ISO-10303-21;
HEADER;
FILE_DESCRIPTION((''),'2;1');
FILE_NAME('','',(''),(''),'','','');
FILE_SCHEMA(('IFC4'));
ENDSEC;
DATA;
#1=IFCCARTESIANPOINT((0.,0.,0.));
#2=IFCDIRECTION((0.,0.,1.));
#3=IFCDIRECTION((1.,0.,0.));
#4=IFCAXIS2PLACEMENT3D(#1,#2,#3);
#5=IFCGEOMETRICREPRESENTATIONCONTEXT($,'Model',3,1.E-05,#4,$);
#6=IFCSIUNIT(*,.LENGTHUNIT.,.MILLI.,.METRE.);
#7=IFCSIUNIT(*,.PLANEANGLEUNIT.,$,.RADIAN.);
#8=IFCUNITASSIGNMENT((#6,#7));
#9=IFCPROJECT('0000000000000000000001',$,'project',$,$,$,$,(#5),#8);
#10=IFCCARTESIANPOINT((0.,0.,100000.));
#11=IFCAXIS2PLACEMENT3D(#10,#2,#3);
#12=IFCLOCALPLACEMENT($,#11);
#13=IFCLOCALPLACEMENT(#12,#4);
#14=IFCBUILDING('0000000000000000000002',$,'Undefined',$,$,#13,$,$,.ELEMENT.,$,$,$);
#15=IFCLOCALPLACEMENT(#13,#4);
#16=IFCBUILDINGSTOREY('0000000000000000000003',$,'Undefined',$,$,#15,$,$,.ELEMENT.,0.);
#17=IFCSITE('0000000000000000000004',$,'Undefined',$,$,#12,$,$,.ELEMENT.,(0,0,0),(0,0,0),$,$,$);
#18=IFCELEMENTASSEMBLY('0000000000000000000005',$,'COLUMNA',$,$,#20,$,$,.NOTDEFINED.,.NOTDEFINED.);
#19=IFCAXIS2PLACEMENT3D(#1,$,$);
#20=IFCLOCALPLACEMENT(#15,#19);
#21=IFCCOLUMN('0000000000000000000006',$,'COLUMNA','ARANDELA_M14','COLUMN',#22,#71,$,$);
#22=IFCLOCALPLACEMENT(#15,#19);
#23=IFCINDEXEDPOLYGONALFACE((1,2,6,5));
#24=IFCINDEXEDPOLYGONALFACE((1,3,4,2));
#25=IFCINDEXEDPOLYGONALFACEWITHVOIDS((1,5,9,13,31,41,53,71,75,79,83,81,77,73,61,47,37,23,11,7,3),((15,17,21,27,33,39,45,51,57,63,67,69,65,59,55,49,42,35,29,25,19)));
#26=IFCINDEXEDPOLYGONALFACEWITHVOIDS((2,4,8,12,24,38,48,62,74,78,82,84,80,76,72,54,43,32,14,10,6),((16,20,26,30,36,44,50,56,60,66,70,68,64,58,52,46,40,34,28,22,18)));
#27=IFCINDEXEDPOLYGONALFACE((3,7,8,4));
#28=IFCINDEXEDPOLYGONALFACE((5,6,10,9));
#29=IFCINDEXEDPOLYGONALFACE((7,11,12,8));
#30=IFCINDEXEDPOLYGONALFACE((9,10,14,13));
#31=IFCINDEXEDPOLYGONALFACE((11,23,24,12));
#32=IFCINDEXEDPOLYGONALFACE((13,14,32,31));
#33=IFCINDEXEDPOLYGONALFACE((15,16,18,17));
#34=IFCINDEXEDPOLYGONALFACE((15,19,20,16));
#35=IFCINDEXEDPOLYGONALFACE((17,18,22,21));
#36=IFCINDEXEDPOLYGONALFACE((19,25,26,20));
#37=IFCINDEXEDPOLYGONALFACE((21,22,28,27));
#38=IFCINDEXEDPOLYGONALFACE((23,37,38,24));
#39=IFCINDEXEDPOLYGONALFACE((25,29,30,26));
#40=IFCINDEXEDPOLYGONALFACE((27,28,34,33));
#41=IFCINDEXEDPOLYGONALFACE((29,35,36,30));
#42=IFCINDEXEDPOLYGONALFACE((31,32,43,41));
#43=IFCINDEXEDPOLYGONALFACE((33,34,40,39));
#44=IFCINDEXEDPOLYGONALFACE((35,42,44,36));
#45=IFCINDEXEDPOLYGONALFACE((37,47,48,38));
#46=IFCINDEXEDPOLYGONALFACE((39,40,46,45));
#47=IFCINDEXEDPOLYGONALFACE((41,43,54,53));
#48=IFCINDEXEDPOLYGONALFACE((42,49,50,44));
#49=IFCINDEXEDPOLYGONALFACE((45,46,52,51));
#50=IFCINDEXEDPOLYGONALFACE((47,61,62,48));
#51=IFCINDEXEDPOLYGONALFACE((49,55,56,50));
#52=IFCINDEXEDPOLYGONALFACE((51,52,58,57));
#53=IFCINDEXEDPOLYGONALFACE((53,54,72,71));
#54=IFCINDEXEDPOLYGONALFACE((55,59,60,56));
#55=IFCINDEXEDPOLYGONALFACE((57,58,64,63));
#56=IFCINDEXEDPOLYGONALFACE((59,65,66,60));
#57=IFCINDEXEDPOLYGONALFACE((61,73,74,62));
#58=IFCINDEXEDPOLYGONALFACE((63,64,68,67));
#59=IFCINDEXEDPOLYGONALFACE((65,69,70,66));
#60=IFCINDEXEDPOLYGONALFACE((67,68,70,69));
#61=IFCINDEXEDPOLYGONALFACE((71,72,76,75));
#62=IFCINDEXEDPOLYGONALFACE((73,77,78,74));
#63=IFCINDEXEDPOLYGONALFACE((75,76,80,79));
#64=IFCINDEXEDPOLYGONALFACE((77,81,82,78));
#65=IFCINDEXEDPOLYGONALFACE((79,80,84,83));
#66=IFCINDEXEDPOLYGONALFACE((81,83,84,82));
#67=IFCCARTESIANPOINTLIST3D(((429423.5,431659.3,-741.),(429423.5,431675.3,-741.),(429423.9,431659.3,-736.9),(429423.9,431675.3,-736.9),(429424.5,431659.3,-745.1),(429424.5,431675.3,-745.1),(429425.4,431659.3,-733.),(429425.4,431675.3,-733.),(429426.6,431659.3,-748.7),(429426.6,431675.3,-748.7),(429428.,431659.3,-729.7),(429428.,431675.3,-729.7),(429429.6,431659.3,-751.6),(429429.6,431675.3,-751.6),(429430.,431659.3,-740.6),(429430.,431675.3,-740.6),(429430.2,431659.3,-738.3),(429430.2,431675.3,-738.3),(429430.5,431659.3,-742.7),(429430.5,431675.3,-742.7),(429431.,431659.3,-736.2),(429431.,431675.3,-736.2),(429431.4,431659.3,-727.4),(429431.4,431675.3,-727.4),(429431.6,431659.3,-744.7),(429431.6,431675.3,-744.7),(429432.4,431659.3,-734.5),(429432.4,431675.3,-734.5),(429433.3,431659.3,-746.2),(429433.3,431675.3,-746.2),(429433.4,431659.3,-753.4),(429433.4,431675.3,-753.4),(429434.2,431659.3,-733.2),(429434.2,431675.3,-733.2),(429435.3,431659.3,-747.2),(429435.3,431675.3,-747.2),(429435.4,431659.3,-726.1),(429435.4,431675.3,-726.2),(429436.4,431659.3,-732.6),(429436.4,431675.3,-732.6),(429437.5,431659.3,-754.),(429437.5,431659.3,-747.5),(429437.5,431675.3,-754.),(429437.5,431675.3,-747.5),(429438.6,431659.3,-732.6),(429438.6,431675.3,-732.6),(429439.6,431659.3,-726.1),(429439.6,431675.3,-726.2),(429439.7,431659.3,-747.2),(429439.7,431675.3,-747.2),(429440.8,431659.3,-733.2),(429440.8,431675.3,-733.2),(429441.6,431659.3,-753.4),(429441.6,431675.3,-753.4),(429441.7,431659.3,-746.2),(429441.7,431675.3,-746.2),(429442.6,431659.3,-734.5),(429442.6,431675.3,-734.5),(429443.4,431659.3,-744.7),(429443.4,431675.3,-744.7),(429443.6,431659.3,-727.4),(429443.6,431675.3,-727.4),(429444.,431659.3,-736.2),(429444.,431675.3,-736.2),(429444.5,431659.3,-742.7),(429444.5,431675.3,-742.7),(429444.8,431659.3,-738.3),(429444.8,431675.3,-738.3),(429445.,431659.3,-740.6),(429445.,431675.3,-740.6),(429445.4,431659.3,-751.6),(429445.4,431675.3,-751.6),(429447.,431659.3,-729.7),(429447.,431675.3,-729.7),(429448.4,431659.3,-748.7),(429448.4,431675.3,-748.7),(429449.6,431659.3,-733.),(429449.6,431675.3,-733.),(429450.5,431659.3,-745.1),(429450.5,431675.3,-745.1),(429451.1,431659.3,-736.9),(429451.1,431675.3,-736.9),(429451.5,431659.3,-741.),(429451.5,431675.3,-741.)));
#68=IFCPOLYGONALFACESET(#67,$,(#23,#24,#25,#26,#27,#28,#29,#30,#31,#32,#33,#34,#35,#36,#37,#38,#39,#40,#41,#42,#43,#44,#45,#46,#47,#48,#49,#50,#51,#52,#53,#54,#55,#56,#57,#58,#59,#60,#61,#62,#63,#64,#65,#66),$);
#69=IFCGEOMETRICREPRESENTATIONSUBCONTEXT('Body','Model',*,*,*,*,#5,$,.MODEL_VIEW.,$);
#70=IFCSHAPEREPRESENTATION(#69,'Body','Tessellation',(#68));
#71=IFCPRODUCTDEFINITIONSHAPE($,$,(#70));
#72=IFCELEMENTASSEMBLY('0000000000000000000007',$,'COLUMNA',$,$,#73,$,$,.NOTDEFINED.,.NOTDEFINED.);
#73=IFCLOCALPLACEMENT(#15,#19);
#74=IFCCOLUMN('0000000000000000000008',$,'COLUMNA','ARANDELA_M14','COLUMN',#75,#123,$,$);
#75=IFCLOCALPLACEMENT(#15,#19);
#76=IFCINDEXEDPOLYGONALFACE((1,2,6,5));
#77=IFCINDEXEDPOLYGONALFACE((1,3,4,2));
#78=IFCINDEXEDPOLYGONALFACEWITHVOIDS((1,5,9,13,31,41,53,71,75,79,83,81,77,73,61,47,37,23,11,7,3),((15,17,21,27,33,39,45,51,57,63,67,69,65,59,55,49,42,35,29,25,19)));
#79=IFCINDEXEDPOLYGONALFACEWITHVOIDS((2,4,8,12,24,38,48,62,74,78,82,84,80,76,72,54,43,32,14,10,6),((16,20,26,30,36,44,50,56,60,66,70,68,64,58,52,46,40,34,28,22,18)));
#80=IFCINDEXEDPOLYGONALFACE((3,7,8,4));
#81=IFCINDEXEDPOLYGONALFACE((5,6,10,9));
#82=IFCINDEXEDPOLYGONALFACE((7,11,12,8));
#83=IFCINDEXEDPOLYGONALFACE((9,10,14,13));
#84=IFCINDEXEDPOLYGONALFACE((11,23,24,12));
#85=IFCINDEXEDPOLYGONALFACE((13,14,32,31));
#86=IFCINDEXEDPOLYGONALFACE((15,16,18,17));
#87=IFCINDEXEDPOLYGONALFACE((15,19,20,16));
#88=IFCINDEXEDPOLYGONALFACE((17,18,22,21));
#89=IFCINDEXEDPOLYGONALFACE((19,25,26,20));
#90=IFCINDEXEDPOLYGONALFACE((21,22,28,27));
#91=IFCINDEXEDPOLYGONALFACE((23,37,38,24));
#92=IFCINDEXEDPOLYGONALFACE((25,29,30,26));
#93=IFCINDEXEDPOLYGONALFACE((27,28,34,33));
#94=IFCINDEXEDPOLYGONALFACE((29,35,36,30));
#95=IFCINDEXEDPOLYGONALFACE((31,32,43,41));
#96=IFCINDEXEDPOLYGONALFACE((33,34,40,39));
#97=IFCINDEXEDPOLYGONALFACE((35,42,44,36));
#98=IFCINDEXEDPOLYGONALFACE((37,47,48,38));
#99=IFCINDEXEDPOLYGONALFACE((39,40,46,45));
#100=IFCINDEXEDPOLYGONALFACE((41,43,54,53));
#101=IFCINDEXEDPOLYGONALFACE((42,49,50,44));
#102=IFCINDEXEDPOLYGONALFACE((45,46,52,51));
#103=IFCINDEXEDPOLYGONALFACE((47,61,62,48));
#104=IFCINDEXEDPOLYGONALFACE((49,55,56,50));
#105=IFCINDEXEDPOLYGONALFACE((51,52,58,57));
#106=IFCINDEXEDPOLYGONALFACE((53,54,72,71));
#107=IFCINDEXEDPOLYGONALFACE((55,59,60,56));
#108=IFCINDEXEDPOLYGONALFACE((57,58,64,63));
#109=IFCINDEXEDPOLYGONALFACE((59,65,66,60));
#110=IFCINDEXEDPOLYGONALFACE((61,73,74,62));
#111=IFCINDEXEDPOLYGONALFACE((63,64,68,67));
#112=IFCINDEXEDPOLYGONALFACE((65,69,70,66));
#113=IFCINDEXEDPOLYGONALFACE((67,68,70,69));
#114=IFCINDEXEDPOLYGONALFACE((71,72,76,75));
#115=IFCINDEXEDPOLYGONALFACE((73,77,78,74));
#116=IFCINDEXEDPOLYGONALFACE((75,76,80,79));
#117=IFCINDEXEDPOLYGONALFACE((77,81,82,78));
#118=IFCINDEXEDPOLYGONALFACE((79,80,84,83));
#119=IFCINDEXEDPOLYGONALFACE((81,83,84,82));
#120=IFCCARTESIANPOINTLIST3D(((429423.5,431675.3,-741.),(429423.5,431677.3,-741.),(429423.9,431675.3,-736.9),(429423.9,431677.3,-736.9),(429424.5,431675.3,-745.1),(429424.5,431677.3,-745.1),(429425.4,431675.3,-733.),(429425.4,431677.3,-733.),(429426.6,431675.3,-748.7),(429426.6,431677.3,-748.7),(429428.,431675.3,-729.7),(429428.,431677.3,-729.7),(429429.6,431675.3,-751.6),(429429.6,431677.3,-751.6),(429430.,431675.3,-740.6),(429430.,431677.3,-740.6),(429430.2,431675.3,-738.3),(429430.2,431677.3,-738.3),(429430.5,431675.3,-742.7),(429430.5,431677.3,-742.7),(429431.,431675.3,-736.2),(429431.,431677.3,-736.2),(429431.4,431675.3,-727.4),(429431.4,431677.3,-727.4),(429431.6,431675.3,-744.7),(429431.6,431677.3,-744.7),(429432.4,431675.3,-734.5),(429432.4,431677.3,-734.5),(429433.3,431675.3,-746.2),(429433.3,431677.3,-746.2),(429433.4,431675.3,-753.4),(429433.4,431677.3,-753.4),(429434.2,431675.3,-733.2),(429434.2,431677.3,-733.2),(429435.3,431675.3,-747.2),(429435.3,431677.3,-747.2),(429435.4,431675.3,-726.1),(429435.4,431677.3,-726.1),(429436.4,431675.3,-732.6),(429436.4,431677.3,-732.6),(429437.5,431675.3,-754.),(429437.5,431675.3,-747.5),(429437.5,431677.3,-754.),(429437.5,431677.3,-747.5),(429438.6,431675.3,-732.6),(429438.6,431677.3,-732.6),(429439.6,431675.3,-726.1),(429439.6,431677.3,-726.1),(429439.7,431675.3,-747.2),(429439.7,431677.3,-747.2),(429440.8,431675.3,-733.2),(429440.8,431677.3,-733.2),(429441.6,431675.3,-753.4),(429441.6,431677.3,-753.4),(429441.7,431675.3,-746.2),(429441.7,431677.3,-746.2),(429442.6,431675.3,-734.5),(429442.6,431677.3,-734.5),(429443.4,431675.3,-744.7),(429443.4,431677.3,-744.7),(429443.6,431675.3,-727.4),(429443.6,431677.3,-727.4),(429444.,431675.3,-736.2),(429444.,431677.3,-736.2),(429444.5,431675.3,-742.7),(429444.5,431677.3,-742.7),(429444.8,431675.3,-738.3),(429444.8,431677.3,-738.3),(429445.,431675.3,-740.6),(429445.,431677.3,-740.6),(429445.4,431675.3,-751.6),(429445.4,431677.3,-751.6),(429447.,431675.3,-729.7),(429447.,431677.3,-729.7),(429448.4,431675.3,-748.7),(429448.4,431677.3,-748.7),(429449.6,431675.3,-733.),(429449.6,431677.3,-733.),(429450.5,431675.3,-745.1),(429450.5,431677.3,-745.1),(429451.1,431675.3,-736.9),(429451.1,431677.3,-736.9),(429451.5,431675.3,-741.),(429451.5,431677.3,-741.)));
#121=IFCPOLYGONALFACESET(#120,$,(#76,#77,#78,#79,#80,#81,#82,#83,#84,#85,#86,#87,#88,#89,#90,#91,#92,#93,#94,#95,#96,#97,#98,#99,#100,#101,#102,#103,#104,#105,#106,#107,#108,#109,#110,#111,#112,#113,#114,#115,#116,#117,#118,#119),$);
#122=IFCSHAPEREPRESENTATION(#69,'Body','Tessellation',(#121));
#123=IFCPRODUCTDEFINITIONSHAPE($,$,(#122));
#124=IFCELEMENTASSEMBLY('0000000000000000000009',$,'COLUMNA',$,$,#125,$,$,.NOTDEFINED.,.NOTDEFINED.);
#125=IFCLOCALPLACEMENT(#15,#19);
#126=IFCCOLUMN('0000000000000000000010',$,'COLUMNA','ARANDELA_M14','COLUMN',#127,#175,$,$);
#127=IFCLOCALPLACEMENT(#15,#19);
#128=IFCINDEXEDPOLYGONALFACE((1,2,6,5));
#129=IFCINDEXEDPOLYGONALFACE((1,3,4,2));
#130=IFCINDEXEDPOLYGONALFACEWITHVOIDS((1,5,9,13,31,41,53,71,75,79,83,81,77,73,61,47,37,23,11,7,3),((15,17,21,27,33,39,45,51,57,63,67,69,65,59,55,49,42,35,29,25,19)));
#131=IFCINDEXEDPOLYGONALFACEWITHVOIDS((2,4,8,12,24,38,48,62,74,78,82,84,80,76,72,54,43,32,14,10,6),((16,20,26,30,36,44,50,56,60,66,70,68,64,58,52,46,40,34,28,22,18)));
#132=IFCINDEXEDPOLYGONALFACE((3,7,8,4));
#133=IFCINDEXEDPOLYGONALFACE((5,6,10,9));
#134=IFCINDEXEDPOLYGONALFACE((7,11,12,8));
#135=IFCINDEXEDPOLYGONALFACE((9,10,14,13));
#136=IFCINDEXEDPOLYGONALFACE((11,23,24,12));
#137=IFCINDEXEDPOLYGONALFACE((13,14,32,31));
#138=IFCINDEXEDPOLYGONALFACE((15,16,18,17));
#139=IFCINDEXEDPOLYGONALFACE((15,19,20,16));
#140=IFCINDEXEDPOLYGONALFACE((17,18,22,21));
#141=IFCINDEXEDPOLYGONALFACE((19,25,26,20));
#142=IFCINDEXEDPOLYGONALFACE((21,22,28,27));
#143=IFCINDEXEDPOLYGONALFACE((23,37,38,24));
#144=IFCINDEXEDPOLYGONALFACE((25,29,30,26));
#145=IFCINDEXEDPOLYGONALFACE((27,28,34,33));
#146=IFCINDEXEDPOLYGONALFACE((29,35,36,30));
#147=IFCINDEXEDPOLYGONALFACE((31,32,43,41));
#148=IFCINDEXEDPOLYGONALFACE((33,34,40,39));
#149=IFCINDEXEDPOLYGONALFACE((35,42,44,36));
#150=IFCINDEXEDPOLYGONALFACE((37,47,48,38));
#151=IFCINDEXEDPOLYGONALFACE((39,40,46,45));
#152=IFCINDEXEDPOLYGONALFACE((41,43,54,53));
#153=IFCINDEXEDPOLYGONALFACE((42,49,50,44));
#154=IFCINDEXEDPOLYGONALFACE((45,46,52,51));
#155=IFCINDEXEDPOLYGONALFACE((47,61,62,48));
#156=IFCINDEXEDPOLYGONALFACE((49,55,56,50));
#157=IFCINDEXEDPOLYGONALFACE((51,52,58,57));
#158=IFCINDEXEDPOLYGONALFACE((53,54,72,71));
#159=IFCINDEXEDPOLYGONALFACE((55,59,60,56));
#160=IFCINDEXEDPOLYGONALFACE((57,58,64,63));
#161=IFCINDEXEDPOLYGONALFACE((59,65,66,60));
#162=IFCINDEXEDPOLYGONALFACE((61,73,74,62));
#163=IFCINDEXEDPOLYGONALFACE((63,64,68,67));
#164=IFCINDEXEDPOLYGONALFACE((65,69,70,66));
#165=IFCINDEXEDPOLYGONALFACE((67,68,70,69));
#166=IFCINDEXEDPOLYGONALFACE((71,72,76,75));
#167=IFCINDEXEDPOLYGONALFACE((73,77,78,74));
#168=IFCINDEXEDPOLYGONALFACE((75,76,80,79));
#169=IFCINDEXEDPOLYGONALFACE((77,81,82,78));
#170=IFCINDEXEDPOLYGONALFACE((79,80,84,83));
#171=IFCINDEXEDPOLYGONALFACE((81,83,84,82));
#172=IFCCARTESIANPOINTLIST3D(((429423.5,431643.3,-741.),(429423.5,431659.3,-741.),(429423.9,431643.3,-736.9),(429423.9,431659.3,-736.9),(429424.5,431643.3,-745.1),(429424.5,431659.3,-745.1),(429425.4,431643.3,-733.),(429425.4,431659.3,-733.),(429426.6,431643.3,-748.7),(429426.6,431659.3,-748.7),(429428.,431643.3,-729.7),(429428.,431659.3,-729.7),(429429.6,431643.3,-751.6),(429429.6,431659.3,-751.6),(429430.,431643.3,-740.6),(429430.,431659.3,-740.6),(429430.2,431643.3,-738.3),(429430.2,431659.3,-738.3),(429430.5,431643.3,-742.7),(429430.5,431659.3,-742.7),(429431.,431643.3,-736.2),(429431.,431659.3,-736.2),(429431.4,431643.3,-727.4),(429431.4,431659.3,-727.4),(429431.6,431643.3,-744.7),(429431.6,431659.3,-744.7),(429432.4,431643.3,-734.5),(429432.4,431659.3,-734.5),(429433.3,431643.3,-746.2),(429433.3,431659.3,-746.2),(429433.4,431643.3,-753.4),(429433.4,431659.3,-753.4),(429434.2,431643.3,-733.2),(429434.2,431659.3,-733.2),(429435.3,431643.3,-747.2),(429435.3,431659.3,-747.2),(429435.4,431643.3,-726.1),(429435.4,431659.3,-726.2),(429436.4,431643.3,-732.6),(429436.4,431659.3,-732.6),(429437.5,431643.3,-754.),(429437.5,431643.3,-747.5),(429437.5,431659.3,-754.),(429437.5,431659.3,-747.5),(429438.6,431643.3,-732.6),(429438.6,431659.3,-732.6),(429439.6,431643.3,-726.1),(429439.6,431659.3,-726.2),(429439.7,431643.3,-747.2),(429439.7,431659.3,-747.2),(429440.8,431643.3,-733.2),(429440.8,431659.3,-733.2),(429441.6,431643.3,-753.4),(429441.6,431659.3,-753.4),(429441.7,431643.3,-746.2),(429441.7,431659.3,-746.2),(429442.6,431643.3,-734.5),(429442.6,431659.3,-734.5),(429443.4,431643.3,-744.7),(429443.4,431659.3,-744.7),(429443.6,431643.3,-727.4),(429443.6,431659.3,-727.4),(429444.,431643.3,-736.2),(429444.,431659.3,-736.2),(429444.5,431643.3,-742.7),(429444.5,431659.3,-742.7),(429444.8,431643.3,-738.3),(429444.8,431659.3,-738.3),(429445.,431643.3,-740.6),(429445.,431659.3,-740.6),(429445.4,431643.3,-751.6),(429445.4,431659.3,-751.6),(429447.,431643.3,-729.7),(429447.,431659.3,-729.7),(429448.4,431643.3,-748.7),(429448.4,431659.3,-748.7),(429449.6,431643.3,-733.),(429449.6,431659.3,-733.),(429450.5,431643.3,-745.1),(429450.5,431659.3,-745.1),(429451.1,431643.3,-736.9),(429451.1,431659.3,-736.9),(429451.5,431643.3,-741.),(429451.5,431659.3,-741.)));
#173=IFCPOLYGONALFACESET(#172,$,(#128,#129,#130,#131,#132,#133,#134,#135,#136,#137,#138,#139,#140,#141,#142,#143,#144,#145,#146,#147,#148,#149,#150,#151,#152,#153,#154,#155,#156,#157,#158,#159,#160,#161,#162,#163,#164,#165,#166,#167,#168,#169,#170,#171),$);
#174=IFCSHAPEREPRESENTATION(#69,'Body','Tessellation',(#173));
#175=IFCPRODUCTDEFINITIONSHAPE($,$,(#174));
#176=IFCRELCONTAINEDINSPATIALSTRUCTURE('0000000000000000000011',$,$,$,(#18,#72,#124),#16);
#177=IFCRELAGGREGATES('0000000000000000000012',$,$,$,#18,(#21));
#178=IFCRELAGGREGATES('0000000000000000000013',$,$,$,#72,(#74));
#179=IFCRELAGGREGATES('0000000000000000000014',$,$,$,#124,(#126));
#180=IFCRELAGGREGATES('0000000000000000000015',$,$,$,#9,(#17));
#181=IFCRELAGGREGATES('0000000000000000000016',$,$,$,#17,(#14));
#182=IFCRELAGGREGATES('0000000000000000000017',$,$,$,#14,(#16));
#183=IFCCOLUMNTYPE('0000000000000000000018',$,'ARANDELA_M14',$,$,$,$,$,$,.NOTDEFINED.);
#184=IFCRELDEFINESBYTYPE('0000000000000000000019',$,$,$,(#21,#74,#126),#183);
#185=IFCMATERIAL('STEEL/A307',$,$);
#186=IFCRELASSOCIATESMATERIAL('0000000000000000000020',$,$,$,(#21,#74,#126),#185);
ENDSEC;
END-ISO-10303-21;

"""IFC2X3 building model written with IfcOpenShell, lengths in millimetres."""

from ifc_helpers import new_model, si_unit, frame, origin_with_axes, origin_2d_with_axis, place, context, subcontext, project, spatial, hollow_circle, extrude, material, type_object, element, aggregate, save


model = new_model("IFC2X3")

# Units and contexts
model_context = context("Model", 3, precision=1e-05, world=origin_with_axes())
body_context = subcontext(model_context, "Body", "Model", "MODEL_VIEW")
ifc_project = project(units=[si_unit("LENGTHUNIT", "METRE", prefix="MILLI"), si_unit("PLANEANGLEUNIT", "RADIAN")], contexts=[model_context])

# Site, building, storey
site_placement = place(None, frame((0.0, 0.0, 100000.0), z_axis=(0.0, 0.0, 1.0), x_axis=(1.0, 0.0, 0.0)))
site = spatial("IfcSite", under=ifc_project, at=site_placement, Name="Undefined", CompositionType="ELEMENT", RefLatitude=(0, 0, 0), RefLongitude=(0, 0, 0))
building_placement = place(site_placement, origin_with_axes())
building = spatial("IfcBuilding", under=site, at=building_placement, Name="Undefined", CompositionType="ELEMENT")
storey_placement = place(building_placement, origin_with_axes())
storey = spatial("IfcBuildingStorey", under=building, at=storey_placement, Name="Undefined", CompositionType="ELEMENT", Elevation=0.0)

# Element assemblies, columns
assembly_1_placement = place(storey_placement, origin_with_axes())
assembly_1 = element("IfcElementAssembly", 1, at=assembly_1_placement, inside=storey, Name="COLUMNA", AssemblyPlace="NOTDEFINED", PredefinedType="NOTDEFINED")
ifc_material_1 = material(Name="STEEL/A307")
column_type_1 = type_object("IfcColumnType", Name="ARANDELA_M14", PredefinedType="NOTDEFINED")
column_1_placement = place(assembly_1_placement, frame((429437.5, 431675.3, -740.0), z_axis=(0.0, -1.0, 0.000285), x_axis=(-1.0, 0.0, 0.0)))
column_1 = element("IfcColumn", 2, at=column_1_placement, type_object=column_type_1, material=ifc_material_1, Name="COLUMNA", Description="ARANDELA_M14", ObjectType="COLUMN", context=body_context, shape_type="SweptSolid", body=[
    extrude(hollow_circle(Radius=14.0, WallThickness=6.5, at=origin_2d_with_axis()), frame((0.0, 0.0, 16.0), z_axis=(0.0, 0.0, -1.0), x_axis=(0.0, 1.0, 0.0)), (0.0, 0.0, 1.0), 16.0),
])
aggregate(assembly_1, [column_1])
assembly_2_placement = place(storey_placement, origin_with_axes())
assembly_2 = element("IfcElementAssembly", 3, at=assembly_2_placement, inside=storey, Name="COLUMNA", AssemblyPlace="NOTDEFINED", PredefinedType="NOTDEFINED")
column_2_placement = place(assembly_2_placement, frame((429437.5, 431677.3, -740.0), z_axis=(0.0, -1.0, 0.000285), x_axis=(-1.0, 0.0, 0.0)))
column_2 = element("IfcColumn", 4, at=column_2_placement, type_object=column_type_1, material=ifc_material_1, Name="COLUMNA", Description="ARANDELA_M14", ObjectType="COLUMN", context=body_context, shape_type="SweptSolid", body=[
    extrude(hollow_circle(Radius=14.0, WallThickness=6.5, at=origin_2d_with_axis()), frame((0.0, 0.0, 2.0), z_axis=(0.0, 0.0, -1.0), x_axis=(0.0, 1.0, 0.0)), (0.0, 0.0, 1.0), 2.0),
])
aggregate(assembly_2, [column_2])
assembly_3_placement = place(storey_placement, origin_with_axes())
assembly_3 = element("IfcElementAssembly", 5, at=assembly_3_placement, inside=storey, Name="COLUMNA", AssemblyPlace="NOTDEFINED", PredefinedType="NOTDEFINED")
column_3_placement = place(assembly_3_placement, frame((429437.5, 431659.3, -740.0), z_axis=(0.0, -1.0, 0.000285), x_axis=(-1.0, 0.0, 0.0)))
column_3 = element("IfcColumn", 6, at=column_3_placement, type_object=column_type_1, material=ifc_material_1, Name="COLUMNA", Description="ARANDELA_M14", ObjectType="COLUMN", context=body_context, shape_type="SweptSolid", body=[
    extrude(hollow_circle(Radius=14.0, WallThickness=6.5, at=origin_2d_with_axis()), frame((0.0, 0.0, 16.0), z_axis=(0.0, 0.0, -1.0), x_axis=(0.0, 1.0, 0.0)), (0.0, 0.0, 1.0), 16.0),
])
aggregate(assembly_3, [column_3])

save(model, "model.ifc")
